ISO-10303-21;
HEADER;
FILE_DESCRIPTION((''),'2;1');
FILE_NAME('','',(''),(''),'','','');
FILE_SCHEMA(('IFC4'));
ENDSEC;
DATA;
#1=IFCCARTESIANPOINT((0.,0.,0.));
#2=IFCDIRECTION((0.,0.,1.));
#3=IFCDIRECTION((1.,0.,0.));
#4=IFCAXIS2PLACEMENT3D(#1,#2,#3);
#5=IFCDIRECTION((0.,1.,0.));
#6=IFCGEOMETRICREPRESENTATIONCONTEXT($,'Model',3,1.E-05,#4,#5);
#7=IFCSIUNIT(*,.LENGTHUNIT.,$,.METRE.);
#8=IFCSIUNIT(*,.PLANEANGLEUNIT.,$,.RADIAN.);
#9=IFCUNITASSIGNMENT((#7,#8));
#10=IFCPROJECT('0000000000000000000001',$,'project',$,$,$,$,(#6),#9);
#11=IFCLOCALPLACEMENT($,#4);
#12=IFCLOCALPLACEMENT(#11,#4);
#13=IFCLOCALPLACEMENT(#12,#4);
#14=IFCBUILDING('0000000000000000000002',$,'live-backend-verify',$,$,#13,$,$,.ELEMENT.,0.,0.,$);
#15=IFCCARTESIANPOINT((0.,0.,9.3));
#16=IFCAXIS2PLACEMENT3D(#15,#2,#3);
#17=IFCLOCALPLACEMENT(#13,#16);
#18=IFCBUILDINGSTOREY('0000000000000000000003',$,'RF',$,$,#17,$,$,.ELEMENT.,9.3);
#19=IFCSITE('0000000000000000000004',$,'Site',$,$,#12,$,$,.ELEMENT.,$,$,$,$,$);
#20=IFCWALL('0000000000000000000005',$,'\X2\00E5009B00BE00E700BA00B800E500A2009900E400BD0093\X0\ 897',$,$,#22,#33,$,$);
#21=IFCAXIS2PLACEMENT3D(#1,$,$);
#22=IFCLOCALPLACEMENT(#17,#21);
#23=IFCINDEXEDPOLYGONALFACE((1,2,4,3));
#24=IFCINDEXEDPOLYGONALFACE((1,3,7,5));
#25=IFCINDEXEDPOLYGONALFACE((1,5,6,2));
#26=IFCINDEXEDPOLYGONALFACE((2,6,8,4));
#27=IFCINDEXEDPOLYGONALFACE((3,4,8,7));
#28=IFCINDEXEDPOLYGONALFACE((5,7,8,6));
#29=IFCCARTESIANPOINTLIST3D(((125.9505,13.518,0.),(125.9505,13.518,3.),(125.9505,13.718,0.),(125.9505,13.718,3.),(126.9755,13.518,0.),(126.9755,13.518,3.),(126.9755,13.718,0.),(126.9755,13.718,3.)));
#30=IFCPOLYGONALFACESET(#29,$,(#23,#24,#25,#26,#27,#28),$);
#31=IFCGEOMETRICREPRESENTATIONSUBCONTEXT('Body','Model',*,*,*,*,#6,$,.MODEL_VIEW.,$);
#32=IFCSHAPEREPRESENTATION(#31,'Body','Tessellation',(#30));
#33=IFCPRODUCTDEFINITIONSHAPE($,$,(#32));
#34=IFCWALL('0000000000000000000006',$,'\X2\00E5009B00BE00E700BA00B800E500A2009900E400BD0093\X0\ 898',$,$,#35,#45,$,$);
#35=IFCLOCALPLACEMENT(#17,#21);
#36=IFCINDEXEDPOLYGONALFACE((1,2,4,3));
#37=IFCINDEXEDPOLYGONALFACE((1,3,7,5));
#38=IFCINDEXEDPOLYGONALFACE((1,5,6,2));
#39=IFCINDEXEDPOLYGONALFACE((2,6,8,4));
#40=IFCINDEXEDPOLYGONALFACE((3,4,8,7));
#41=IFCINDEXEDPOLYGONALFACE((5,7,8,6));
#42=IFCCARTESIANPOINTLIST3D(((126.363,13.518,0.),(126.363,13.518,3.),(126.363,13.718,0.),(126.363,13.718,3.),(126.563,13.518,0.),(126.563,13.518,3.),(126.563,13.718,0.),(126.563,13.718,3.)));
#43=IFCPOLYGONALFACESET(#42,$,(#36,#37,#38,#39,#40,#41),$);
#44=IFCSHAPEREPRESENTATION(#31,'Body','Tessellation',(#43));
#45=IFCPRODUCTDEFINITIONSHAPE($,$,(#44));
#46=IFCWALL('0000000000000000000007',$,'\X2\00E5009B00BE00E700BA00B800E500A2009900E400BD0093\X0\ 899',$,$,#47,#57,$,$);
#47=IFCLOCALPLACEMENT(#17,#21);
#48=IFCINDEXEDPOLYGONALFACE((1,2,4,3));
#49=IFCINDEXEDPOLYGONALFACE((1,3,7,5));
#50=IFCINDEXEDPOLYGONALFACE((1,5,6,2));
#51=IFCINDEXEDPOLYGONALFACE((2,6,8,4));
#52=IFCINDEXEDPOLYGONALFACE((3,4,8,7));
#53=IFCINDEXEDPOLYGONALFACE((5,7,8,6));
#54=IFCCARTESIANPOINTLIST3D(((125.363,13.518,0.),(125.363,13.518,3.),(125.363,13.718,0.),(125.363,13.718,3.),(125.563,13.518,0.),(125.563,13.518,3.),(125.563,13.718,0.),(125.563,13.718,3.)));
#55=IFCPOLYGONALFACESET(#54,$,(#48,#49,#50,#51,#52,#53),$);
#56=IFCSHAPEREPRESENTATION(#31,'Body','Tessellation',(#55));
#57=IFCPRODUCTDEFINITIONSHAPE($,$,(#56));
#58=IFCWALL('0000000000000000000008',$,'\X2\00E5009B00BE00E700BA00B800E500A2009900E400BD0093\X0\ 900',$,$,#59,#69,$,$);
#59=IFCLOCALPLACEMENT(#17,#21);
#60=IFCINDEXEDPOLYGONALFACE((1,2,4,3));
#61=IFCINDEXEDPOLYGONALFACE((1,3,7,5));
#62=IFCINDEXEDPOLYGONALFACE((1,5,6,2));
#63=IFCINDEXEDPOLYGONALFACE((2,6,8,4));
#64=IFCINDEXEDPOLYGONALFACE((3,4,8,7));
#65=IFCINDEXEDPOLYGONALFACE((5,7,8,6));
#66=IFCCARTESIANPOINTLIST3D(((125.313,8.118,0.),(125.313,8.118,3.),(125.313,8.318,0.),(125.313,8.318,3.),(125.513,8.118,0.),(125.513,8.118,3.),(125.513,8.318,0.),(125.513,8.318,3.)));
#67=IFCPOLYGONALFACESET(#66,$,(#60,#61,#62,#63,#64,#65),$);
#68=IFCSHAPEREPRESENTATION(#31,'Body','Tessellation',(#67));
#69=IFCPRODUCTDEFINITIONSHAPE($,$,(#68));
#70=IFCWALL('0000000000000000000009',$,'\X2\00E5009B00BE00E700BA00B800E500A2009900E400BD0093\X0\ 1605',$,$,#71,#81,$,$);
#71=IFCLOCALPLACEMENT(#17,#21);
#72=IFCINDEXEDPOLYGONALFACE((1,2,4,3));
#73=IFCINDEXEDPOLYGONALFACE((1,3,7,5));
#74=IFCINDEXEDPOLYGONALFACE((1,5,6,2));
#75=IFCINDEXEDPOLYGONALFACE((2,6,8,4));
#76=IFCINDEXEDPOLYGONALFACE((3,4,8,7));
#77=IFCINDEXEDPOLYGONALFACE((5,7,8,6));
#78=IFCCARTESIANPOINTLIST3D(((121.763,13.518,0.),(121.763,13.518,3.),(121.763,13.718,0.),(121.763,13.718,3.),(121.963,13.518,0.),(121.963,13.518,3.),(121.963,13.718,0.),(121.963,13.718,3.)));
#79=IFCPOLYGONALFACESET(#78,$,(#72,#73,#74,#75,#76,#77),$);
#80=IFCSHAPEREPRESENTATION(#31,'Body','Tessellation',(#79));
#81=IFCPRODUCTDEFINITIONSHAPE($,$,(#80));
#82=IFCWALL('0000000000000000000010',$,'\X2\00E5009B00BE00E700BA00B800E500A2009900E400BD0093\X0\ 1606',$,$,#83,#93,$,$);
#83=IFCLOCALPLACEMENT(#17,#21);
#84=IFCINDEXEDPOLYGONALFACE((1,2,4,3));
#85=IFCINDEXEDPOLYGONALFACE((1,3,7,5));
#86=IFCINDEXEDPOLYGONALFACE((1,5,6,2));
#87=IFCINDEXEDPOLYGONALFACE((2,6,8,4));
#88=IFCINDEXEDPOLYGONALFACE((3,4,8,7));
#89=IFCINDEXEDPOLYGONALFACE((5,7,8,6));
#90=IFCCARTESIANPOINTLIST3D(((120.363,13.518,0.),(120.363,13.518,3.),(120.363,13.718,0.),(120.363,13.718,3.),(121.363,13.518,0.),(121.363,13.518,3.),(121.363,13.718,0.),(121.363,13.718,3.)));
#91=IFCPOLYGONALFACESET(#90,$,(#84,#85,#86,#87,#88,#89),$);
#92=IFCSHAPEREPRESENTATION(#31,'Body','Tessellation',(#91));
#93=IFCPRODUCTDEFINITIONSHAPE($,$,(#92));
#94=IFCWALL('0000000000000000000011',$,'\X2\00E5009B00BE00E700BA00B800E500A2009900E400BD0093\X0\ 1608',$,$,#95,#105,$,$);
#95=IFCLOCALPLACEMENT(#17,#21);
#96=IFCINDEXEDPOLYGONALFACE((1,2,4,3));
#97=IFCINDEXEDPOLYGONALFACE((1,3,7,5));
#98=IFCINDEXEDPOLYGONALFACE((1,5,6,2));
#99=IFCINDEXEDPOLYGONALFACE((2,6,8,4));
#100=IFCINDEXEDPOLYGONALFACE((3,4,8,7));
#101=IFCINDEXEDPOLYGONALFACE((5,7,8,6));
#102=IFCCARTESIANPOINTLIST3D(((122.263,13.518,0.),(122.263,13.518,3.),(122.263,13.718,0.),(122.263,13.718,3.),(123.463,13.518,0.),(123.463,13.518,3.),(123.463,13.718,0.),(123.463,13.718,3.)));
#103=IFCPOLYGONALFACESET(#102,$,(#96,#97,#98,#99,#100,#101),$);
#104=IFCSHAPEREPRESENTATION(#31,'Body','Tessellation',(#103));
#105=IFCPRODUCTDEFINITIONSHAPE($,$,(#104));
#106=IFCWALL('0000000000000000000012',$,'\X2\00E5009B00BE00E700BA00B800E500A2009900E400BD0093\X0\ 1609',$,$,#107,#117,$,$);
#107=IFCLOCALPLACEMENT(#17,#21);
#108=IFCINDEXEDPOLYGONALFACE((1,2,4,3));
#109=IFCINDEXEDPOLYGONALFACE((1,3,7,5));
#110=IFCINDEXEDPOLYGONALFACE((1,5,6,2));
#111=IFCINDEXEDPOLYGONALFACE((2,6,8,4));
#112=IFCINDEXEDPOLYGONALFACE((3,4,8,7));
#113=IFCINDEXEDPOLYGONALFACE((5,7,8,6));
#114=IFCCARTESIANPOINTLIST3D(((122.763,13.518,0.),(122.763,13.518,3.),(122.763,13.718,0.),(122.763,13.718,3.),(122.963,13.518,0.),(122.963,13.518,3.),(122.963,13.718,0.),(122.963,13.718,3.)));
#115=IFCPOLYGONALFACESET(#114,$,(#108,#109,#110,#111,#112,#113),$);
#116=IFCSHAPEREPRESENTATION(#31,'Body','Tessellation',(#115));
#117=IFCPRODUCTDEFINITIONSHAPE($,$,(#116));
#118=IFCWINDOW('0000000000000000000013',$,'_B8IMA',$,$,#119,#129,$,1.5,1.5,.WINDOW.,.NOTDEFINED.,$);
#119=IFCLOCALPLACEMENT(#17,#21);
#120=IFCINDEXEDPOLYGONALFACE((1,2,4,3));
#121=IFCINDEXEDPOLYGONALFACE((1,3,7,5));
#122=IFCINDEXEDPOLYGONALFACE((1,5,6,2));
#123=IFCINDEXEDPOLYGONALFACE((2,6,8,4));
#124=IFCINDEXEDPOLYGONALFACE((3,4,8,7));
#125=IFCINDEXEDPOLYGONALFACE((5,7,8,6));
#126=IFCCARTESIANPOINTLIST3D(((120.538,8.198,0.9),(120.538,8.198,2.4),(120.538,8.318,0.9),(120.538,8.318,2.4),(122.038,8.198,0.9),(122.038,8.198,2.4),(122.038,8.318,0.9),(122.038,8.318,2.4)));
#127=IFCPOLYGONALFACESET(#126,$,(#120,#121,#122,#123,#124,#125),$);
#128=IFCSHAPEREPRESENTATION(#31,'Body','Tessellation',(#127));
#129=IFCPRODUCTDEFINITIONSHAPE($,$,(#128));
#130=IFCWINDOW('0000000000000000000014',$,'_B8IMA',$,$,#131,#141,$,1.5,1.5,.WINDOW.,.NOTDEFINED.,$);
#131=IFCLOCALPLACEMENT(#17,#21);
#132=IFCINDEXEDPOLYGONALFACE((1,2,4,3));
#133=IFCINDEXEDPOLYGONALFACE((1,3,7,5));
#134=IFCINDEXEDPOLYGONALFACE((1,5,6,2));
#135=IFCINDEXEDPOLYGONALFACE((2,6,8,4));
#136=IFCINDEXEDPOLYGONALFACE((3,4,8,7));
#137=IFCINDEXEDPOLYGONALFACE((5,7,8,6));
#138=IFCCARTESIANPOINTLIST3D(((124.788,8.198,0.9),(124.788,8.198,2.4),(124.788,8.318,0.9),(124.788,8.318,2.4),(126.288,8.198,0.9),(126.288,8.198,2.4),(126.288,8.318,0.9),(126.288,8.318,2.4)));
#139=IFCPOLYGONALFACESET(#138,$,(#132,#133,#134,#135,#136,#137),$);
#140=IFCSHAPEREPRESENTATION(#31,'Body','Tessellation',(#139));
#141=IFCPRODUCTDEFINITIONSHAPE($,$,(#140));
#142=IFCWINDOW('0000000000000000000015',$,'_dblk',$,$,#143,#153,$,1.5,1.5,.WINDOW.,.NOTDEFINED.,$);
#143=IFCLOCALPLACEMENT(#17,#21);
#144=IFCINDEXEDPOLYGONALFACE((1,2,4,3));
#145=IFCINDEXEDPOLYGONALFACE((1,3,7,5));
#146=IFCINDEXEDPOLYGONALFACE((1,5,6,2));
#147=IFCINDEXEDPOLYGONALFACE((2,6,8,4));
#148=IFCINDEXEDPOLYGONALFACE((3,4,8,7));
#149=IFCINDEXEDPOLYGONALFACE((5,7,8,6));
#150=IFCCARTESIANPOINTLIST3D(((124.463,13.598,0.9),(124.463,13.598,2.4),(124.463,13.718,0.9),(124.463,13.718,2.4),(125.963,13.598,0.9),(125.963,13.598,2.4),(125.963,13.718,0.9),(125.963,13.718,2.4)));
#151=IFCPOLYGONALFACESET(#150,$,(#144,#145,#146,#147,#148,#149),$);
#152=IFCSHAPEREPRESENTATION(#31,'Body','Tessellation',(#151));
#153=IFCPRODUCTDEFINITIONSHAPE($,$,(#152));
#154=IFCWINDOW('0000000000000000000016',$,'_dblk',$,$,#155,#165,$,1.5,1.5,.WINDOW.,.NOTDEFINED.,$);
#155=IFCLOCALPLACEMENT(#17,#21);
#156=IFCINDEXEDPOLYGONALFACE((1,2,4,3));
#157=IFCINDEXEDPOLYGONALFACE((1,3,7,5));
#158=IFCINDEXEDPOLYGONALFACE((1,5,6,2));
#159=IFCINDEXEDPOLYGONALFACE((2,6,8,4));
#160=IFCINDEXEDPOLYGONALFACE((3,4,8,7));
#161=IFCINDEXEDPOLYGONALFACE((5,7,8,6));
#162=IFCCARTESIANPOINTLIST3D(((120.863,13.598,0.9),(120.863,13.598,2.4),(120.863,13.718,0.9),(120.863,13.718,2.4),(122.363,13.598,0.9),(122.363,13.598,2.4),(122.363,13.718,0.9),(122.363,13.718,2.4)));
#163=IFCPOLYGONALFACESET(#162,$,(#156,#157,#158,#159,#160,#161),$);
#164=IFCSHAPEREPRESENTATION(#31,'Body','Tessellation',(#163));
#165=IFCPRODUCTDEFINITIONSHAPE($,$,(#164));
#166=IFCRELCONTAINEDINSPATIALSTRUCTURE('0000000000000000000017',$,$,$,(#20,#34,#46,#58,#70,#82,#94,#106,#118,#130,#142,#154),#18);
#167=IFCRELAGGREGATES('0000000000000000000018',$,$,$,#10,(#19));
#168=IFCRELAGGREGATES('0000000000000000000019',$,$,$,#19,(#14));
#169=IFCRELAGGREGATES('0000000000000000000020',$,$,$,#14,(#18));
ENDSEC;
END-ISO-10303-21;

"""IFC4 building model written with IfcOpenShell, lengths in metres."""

from ifc_helpers import new_model, si_unit, direction, frame, frame_2d, origin_with_axes, place, context, subcontext, project, spatial, rectangle, extrude, element, save


model = new_model("IFC4")

# Units and contexts
model_context = context("Model", 3, precision=1e-05, world=origin_with_axes(), true_north=direction((0.0, 1.0, 0.0)))
body_context = subcontext(model_context, "Body", "Model", "MODEL_VIEW")
ifc_project = project(units=[si_unit("LENGTHUNIT", "METRE"), si_unit("PLANEANGLEUNIT", "RADIAN")], contexts=[model_context])

# Site, building, storey
placement = place(None, origin_with_axes())
site_placement = place(placement, origin_with_axes())
site = spatial("IfcSite", under=ifc_project, at=site_placement, Name="Site", CompositionType="ELEMENT")
building_placement = place(site_placement, origin_with_axes())
building = spatial("IfcBuilding", under=site, at=building_placement, Name="live-backend-verify", CompositionType="ELEMENT", ElevationOfRefHeight=0.0, ElevationOfTerrain=0.0)
storey_placement = place(building_placement, frame((0.0, 0.0, 9.3), z_axis=(0.0, 0.0, 1.0), x_axis=(1.0, 0.0, 0.0)))
storey = spatial("IfcBuildingStorey", under=building, at=storey_placement, Name="RF", CompositionType="ELEMENT", Elevation=9.3)

# Walls
wall_1_placement = place(storey_placement, frame((126.463, 13.618, 0.0), z_axis=(0.0, 0.0, 1.0), x_axis=(1.0, 0.0, 0.0)))
element("IfcWall", 1, at=wall_1_placement, inside=storey, Name="å\u009b¾çº¸å¢\u0099ä½\u0093 897", context=body_context, shape_type="SweptSolid", body=[
    extrude(rectangle(XDim=1.025, YDim=0.2, at=frame_2d((0.0, 0.0), x_axis=(1.0, 0.0, 0.0))), frame((0.0, 0.0, 0.0), z_axis=(0.0, 0.0, 1.0)), (0.0, 0.0, 1.0), 3.0),
])
for number, where, z_axis, x_axis, name in (
    (2, (126.463, 13.618, 0.0), (0.0, 0.0, 1.0), (0.0, 1.0, 0.0), "å\u009b¾çº¸å¢\u0099ä½\u0093 898"),
    (3, (125.463, 13.618, 0.0), (0.0, 0.0, 1.0), (0.0, 1.0, 0.0), "å\u009b¾çº¸å¢\u0099ä½\u0093 899"),
    (4, (125.413, 8.218, 0.0), (0.0, 0.0, 1.0), (0.0, 1.0, 0.0), "å\u009b¾çº¸å¢\u0099ä½\u0093 900"),
    (5, (121.863, 13.618, 0.0), (0.0, 0.0, 1.0), (0.0, 1.0, 0.0), "å\u009b¾çº¸å¢\u0099ä½\u0093 1605"),
):
    element("IfcWall", number, at=place(storey_placement, frame(where, z_axis=z_axis, x_axis=x_axis)), inside=storey, Name=name, context=body_context, shape_type="SweptSolid", body=[
        extrude(rectangle(XDim=0.2, YDim=0.2, at=frame_2d((0.0, 0.0), x_axis=(1.0, 0.0, 0.0))), frame((0.0, 0.0, 0.0), z_axis=(0.0, 0.0, 1.0)), (0.0, 0.0, 1.0), 3.0),
    ])
wall_2_placement = place(storey_placement, frame((120.863, 13.618, 0.0), z_axis=(0.0, 0.0, 1.0), x_axis=(1.0, 0.0, 0.0)))
element("IfcWall", 6, at=wall_2_placement, inside=storey, Name="å\u009b¾çº¸å¢\u0099ä½\u0093 1606", context=body_context, shape_type="SweptSolid", body=[
    extrude(rectangle(XDim=1.0, YDim=0.2, at=frame_2d((0.0, 0.0), x_axis=(1.0, 0.0, 0.0))), frame((0.0, 0.0, 0.0), z_axis=(0.0, 0.0, 1.0)), (0.0, 0.0, 1.0), 3.0),
])
wall_3_placement = place(storey_placement, frame((122.863, 13.618, 0.0), z_axis=(0.0, 0.0, 1.0), x_axis=(1.0, 0.0, 0.0)))
element("IfcWall", 7, at=wall_3_placement, inside=storey, Name="å\u009b¾çº¸å¢\u0099ä½\u0093 1608", context=body_context, shape_type="SweptSolid", body=[
    extrude(rectangle(XDim=1.2, YDim=0.2, at=frame_2d((0.0, 0.0), x_axis=(1.0, 0.0, 0.0))), frame((0.0, 0.0, 0.0), z_axis=(0.0, 0.0, 1.0)), (0.0, 0.0, 1.0), 3.0),
])
wall_4_placement = place(storey_placement, frame((122.863, 13.618, 0.0), z_axis=(0.0, 0.0, 1.0), x_axis=(0.0, 1.0, 0.0)))
element("IfcWall", 8, at=wall_4_placement, inside=storey, Name="å\u009b¾çº¸å¢\u0099ä½\u0093 1609", context=body_context, shape_type="SweptSolid", body=[
    extrude(rectangle(XDim=0.2, YDim=0.2, at=frame_2d((0.0, 0.0), x_axis=(1.0, 0.0, 0.0))), frame((0.0, 0.0, 0.0), z_axis=(0.0, 0.0, 1.0)), (0.0, 0.0, 1.0), 3.0),
])

# Windows
for number, where, z_axis, x_axis, name in (
    (9, (121.288, 8.258, 0.9), (0.0, 0.0, 1.0), (1.0, 0.0, 0.0), "_B8IMA"),
    (10, (125.538, 8.258, 0.9), (0.0, 0.0, 1.0), (1.0, 0.0, 0.0), "_B8IMA"),
    (11, (125.213, 13.658, 0.9), (0.0, 0.0, 1.0), (1.0, 0.0, 0.0), "_dblk"),
    (12, (121.613, 13.658, 0.9), (0.0, 0.0, 1.0), (1.0, 0.0, 0.0), "_dblk"),
):
    element("IfcWindow", number, at=place(storey_placement, frame(where, z_axis=z_axis, x_axis=x_axis)), inside=storey, Name=name, OverallHeight=1.5, OverallWidth=1.5, PartitioningType="NOTDEFINED", PredefinedType="WINDOW", context=body_context, shape_type="SweptSolid", body=[
        extrude(rectangle(XDim=1.5, YDim=0.12, at=frame_2d((0.0, 0.0), x_axis=(1.0, 0.0, 0.0))), frame((0.0, 0.0, 0.0), z_axis=(0.0, 0.0, 1.0)), (0.0, 0.0, 1.0), 1.5),
    ])

save(model, "model.ifc")
